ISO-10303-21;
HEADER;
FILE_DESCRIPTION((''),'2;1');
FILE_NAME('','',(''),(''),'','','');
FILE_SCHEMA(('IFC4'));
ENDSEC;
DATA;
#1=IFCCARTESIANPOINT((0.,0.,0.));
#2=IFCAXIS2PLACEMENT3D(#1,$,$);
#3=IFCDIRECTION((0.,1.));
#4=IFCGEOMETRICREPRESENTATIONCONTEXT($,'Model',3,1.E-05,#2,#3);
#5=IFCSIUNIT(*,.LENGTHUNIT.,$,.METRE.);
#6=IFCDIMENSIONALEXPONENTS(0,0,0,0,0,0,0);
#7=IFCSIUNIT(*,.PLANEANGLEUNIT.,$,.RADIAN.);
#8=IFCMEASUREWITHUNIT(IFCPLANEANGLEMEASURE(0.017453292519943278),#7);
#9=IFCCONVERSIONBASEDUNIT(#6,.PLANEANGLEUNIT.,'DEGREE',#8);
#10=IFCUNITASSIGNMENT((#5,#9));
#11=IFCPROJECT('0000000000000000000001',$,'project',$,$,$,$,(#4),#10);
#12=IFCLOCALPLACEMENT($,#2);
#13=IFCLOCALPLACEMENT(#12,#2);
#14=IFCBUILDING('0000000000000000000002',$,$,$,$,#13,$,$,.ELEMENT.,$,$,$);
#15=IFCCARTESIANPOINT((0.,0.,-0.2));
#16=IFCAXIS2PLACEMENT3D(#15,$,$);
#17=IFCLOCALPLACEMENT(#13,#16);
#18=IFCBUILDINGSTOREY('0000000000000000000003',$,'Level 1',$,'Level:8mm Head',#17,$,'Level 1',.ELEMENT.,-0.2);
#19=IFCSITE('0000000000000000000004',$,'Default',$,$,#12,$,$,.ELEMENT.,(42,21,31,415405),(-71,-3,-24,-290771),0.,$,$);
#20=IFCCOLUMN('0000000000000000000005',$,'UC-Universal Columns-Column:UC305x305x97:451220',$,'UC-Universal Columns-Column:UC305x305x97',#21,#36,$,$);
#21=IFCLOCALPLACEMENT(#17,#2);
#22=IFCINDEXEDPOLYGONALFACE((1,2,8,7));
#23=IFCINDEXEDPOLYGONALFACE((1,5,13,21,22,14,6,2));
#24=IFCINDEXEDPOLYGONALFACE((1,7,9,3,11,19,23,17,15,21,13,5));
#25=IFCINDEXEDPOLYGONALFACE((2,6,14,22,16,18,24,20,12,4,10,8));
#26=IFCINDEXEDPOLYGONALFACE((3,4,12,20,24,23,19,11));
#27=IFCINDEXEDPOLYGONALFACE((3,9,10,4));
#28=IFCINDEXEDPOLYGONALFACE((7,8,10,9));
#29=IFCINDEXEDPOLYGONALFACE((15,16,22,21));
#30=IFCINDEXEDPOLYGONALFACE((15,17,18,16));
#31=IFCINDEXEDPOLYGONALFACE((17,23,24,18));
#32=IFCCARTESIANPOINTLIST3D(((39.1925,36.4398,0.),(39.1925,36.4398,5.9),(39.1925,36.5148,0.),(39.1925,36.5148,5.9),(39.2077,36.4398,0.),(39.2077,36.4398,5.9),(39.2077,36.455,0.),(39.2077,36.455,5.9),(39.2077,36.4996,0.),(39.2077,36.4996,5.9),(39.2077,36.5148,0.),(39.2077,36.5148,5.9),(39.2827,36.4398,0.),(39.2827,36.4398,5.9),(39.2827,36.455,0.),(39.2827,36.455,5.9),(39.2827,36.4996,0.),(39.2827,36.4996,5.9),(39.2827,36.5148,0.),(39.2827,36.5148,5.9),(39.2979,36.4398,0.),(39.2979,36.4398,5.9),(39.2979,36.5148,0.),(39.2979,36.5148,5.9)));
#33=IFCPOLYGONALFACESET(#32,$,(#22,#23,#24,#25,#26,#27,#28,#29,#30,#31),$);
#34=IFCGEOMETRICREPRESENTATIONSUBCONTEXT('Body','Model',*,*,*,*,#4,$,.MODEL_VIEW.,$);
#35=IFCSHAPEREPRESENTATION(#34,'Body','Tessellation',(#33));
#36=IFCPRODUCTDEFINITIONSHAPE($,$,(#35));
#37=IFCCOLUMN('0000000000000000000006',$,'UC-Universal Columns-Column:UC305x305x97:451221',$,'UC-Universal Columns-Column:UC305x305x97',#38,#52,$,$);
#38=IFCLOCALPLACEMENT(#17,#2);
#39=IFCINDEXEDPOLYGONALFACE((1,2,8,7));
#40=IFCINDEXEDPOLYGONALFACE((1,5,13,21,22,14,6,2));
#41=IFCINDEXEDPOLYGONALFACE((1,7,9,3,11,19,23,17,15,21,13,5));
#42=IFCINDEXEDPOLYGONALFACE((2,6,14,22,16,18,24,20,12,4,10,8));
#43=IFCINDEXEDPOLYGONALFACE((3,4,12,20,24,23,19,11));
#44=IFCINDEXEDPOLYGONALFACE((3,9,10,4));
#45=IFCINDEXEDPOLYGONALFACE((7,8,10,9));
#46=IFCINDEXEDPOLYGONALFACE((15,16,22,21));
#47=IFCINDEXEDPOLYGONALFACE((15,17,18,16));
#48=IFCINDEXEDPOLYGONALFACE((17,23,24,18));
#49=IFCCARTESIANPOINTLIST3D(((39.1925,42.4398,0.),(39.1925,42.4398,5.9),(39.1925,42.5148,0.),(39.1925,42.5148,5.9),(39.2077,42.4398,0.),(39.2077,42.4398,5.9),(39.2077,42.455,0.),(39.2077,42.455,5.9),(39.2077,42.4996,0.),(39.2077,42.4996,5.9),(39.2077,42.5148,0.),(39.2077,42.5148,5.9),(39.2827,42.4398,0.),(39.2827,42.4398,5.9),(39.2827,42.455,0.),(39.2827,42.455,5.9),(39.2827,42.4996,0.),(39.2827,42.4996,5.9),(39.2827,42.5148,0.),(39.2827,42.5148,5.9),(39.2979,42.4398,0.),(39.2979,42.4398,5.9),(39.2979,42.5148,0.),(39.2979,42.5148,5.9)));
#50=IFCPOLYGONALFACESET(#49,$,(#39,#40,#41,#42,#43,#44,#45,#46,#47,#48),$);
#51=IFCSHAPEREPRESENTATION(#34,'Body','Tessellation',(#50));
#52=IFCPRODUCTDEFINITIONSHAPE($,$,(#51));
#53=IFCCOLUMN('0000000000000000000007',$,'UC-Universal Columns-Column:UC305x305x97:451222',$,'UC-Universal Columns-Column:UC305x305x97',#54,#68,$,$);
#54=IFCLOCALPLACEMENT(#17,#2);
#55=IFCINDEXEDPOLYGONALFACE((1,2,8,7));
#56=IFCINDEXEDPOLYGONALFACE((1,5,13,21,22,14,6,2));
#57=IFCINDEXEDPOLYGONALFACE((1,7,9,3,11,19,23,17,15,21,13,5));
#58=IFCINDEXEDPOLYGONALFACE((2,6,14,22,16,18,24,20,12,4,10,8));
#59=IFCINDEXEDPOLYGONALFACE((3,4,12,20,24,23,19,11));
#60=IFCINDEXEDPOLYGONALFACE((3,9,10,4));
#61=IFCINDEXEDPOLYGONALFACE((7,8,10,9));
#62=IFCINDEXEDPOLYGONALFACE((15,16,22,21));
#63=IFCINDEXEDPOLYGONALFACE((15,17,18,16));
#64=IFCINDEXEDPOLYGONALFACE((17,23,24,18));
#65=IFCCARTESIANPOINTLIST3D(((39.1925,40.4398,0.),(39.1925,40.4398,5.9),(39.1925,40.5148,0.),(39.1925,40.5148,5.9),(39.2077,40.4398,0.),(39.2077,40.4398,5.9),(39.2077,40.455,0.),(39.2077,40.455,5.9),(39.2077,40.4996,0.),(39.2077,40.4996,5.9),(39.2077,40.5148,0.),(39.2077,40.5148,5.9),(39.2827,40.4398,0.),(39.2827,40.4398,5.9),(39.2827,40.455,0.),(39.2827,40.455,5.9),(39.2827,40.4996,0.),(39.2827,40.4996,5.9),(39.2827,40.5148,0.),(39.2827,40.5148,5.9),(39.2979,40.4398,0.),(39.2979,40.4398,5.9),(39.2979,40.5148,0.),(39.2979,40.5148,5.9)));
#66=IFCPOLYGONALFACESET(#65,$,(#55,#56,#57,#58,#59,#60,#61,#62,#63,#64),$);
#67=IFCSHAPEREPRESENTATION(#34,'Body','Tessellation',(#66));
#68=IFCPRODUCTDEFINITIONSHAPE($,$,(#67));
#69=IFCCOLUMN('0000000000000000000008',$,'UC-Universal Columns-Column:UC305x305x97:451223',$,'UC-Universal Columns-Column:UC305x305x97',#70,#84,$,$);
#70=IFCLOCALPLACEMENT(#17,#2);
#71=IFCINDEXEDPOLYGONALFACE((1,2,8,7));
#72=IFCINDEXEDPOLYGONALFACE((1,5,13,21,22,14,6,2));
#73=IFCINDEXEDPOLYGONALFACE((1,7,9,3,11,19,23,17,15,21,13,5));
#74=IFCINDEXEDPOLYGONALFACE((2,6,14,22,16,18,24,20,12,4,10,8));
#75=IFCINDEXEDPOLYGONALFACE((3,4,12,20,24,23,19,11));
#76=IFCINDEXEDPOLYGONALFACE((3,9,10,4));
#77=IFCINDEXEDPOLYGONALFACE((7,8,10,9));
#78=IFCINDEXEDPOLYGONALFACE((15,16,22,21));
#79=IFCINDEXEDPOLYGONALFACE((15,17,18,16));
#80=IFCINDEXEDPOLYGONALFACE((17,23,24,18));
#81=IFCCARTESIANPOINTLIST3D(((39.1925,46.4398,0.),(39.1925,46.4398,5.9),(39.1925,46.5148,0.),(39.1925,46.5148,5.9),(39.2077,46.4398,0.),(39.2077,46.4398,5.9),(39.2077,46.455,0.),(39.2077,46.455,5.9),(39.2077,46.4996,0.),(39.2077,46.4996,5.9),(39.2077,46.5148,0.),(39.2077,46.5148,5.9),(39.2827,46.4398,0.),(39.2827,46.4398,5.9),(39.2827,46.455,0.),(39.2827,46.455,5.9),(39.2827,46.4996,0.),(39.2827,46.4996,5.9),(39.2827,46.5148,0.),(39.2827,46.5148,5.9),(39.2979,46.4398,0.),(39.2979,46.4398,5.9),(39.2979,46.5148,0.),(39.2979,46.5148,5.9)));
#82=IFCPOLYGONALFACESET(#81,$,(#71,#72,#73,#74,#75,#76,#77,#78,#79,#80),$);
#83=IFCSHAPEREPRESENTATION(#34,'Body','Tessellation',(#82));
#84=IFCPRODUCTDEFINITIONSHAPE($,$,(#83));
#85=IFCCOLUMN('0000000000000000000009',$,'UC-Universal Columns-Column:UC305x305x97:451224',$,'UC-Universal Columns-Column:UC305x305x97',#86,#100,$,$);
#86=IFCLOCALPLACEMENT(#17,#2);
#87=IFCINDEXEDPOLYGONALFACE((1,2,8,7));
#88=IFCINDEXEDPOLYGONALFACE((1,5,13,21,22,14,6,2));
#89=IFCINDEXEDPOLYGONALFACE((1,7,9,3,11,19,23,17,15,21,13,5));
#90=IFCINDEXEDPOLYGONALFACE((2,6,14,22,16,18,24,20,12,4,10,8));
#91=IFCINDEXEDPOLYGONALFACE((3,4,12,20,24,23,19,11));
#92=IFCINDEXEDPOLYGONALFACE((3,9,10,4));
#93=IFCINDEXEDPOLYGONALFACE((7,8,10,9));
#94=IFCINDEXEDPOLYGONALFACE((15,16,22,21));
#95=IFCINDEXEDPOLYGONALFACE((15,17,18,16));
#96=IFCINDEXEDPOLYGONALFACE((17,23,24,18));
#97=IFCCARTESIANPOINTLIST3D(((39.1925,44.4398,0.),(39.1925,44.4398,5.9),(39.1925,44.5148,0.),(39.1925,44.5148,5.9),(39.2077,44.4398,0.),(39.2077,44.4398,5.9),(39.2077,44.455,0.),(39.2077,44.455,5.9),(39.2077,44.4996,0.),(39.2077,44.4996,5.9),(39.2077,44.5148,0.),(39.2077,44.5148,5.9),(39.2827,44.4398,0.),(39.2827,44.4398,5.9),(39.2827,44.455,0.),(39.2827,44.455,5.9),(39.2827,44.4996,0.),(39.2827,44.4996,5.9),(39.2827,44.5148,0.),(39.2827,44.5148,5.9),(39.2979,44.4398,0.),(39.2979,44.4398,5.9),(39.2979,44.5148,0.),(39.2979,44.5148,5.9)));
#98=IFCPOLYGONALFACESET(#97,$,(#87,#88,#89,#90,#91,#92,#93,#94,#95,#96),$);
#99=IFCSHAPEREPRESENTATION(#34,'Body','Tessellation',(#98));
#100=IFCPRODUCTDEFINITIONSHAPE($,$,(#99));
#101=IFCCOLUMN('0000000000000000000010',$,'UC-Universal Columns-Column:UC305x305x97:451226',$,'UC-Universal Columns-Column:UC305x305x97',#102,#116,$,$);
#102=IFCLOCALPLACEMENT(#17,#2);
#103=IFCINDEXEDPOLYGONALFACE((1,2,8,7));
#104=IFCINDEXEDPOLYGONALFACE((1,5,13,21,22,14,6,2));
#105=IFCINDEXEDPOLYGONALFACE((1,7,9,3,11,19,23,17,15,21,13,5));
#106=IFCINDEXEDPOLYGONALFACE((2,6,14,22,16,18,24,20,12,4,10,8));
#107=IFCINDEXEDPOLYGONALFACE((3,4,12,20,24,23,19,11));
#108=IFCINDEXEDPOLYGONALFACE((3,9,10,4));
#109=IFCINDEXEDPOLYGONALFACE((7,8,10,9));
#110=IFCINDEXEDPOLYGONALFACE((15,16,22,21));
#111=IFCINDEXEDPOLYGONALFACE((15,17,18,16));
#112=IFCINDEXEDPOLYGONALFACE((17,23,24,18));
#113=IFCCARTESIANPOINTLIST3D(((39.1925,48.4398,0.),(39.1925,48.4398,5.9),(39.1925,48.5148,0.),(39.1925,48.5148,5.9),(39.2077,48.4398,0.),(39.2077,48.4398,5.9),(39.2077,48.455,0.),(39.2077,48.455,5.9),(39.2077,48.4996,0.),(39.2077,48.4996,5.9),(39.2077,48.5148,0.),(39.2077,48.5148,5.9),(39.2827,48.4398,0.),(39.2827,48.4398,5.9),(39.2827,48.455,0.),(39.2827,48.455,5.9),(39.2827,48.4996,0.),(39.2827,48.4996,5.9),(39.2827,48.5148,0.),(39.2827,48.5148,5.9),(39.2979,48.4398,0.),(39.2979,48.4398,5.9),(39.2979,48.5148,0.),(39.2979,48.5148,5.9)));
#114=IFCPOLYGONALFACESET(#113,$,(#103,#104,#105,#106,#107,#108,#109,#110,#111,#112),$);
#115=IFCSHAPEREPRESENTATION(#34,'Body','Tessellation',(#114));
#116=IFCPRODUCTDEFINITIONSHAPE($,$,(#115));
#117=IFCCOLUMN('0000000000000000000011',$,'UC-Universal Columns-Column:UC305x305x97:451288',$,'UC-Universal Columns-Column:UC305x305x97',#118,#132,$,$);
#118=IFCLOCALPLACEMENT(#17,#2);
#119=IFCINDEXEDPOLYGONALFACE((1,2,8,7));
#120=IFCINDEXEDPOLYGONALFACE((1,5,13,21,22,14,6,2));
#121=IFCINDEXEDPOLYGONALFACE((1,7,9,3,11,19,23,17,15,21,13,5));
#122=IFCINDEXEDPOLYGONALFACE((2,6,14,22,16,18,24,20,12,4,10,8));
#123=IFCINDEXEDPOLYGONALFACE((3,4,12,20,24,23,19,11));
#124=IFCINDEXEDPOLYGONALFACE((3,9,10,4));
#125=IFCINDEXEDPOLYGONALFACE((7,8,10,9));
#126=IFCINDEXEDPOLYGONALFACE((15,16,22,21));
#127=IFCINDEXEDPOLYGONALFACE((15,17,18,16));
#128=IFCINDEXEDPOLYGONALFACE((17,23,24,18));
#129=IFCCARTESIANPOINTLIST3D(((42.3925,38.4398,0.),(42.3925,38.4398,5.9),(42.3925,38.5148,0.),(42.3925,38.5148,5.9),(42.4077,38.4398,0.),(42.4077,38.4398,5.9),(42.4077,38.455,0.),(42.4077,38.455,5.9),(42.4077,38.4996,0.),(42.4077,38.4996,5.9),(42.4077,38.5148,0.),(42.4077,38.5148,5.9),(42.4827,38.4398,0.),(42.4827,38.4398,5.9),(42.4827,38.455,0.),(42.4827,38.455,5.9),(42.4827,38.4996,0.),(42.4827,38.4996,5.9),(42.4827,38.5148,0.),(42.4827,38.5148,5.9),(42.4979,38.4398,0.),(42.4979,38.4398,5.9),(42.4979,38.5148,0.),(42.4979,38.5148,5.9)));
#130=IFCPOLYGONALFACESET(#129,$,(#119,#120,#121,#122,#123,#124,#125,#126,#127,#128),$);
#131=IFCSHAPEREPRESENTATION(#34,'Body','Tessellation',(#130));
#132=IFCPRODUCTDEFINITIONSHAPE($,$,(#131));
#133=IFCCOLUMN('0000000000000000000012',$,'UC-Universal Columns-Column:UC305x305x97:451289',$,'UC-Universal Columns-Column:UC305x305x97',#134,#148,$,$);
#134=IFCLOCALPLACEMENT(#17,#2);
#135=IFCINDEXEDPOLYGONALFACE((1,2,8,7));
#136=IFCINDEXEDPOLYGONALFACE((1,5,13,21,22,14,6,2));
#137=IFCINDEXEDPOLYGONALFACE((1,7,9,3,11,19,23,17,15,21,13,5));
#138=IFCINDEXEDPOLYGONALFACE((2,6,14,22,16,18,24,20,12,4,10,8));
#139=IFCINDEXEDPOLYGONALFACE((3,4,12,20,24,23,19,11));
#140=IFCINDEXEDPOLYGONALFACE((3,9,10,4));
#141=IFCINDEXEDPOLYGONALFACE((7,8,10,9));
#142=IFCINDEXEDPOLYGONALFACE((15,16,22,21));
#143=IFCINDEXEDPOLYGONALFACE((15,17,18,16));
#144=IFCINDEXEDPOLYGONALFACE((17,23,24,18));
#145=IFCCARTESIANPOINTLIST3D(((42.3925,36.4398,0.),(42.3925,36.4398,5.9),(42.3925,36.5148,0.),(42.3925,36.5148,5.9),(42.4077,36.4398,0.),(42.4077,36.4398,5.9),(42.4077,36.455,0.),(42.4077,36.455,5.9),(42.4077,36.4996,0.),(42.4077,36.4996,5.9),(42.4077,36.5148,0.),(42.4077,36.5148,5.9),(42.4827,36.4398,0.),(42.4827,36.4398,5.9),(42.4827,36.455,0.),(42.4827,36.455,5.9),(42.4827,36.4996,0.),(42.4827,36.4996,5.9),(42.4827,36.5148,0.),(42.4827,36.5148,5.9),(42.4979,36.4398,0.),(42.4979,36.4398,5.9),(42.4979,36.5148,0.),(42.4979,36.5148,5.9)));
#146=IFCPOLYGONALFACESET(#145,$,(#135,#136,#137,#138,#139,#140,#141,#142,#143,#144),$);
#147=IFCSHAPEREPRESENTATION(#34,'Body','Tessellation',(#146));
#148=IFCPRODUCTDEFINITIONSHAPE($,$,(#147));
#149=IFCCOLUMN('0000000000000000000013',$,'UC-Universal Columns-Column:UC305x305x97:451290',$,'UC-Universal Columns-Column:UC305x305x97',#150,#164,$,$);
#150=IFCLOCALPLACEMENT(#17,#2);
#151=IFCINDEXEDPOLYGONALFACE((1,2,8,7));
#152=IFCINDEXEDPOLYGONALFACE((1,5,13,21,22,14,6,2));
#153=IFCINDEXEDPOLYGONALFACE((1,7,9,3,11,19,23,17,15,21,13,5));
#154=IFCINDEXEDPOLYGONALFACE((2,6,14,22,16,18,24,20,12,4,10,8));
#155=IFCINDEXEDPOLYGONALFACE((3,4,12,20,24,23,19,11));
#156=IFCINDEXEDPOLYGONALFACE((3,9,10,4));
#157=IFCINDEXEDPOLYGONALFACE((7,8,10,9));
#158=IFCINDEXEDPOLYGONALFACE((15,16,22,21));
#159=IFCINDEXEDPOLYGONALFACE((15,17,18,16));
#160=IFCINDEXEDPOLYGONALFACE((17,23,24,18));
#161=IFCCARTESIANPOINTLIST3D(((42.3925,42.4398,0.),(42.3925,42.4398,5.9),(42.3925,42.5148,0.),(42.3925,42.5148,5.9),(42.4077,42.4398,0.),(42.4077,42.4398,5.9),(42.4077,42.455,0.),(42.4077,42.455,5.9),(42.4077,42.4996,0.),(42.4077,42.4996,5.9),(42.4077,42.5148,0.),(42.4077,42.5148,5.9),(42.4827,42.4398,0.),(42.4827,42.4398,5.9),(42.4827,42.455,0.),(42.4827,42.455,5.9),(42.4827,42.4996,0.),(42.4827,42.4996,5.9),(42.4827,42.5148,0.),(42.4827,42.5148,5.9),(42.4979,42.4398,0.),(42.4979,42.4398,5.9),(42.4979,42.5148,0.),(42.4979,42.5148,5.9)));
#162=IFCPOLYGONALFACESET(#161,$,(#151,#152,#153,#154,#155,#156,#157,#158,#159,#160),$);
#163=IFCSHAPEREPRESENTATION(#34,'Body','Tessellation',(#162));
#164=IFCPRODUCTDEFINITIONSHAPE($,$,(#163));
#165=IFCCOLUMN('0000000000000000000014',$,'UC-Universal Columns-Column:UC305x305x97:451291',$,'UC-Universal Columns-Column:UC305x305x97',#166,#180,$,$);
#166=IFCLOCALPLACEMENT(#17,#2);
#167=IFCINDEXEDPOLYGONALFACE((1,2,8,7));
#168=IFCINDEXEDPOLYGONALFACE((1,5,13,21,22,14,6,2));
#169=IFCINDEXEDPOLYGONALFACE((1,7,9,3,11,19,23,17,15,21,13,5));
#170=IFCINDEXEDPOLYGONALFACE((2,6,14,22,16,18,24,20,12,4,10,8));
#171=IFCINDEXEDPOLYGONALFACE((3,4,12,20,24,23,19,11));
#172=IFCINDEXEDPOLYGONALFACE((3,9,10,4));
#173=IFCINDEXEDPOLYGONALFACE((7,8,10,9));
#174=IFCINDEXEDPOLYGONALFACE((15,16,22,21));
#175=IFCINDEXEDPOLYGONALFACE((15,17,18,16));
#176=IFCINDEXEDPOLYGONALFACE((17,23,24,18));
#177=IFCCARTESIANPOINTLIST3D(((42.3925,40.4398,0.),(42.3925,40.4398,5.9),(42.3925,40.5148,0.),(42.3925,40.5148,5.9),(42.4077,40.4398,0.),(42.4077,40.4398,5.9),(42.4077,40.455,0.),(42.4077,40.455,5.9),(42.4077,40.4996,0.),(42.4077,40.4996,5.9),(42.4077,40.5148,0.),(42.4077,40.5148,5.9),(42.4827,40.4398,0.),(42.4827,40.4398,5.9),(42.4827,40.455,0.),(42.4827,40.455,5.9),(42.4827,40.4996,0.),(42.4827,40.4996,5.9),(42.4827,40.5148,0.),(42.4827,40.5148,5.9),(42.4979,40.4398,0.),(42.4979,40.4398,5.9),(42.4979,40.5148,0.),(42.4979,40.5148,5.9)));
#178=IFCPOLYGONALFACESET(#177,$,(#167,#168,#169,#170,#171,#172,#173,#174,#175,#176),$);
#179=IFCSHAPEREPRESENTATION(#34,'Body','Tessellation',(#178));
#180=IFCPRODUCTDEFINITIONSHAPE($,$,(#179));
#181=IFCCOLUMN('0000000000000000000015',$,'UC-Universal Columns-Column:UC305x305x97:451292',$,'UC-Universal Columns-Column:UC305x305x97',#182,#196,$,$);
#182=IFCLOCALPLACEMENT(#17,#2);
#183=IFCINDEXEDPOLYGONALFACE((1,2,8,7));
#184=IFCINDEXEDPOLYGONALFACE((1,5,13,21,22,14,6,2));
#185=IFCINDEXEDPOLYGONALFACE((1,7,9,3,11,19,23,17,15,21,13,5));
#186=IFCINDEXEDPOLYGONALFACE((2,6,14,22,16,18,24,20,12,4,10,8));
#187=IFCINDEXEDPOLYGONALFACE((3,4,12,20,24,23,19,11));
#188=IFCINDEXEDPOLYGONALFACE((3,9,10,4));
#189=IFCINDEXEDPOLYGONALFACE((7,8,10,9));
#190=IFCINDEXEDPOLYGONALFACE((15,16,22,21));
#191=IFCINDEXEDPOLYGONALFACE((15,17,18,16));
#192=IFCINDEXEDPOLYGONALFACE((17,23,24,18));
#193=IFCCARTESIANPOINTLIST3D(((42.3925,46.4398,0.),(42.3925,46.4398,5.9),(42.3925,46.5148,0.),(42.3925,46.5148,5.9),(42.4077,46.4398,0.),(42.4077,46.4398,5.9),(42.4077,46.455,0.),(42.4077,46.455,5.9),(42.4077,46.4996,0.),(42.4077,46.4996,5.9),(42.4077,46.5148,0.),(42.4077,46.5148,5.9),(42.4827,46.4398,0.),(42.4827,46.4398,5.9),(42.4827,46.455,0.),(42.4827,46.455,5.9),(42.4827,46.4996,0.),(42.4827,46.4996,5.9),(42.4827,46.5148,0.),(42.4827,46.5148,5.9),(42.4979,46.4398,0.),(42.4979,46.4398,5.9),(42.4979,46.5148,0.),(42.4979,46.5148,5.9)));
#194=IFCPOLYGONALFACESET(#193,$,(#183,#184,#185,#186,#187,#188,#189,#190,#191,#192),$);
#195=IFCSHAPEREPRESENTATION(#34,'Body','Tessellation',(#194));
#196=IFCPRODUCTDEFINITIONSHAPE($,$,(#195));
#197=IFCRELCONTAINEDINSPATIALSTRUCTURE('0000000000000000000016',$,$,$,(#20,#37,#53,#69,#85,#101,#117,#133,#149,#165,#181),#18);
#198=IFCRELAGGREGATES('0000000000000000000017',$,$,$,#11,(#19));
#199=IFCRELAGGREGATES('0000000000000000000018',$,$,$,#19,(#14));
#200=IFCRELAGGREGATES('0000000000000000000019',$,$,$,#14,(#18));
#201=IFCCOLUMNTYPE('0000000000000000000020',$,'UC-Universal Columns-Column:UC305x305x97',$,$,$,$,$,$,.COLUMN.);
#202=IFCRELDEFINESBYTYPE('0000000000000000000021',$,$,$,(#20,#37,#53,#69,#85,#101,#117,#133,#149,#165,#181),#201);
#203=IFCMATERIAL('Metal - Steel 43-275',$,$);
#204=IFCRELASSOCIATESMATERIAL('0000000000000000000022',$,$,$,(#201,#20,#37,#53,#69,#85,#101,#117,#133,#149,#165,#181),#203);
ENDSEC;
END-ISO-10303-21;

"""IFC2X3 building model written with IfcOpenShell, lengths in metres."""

from ifc_helpers import new_model, entity, si_unit, converted_unit, direction, frame, frame_2d, origin, place, context, subcontext, project, spatial, polyline, circle_curve, parameter, trimmed, segment, composite_curve, outline, extrude, source, transform, mapped, material, type_object, type_shapes, element, save


model = new_model("IFC2X3")

# Units and contexts
model_context = context("Model", 3, precision=1e-05, world=origin(), true_north=direction((0.0, 1.0)))
body_context = subcontext(model_context, "Body", "Model", "MODEL_VIEW")
ifc_project = project(units=[si_unit("LENGTHUNIT", "METRE"), converted_unit("PLANEANGLEUNIT", "DEGREE", entity("IfcPlaneAngleMeasure", 0.017453292519943278), si_unit("PLANEANGLEUNIT", "RADIAN"), dimensions=[0, 0, 0, 0, 0, 0, 0])], contexts=[model_context])

# Site, building, storey
site_placement = place(None, origin())
site = spatial("IfcSite", under=ifc_project, at=site_placement, Name="Default", CompositionType="ELEMENT", RefLatitude=(42, 21, 31, 415405), RefLongitude=(-71, -3, -24, -290771), RefElevation=0.0)
building_placement = place(site_placement, origin())
building = spatial("IfcBuilding", under=site, at=building_placement, CompositionType="ELEMENT")
storey_placement = place(building_placement, frame((0.0, 0.0, -0.2)))
storey = spatial("IfcBuildingStorey", under=building, at=storey_placement, Name="Level 1", ObjectType="Level:8mm Head", LongName="Level 1", CompositionType="ELEMENT", Elevation=-0.2)

# Columns
ifc_material = material(Name="Metal - Steel 43-275")
column_type = type_object("IfcColumnType", Name="UC-Universal Columns-Column:UC305x305x97", PredefinedType="COLUMN", material=ifc_material)
shared_shape = source(origin(), body_context, "Body", "SweptSolid", [
    extrude(outline(composite_curve([segment(polyline([(-0.0375, -0.0375), (0.0375, -0.0375)]), True, "CONTINUOUS"), segment(polyline([(0.0375, -0.0375), (0.0527, -0.0375)]), True, "CONTINUOUS"), segment(trimmed(circle_curve(frame_2d((0.0527, -0.0223), x_axis=(-1.0, 0.0)), 0.0152), [parameter(0.0)], [parameter(90.0)], True, "PARAMETER"), False, "CONTINUOUS"), segment(polyline([(0.0375, -0.0223), (0.0375, 0.0223)]), True, "CONTINUOUS"), segment(trimmed(circle_curve(frame_2d((0.0527, 0.0223), x_axis=(-1.0, 0.0)), 0.0152), [parameter(270.0)], [parameter(0.0)], True, "PARAMETER"), False, "CONTINUOUS"), segment(polyline([(0.0527, 0.0375), (0.0375, 0.0375)]), True, "CONTINUOUS"), segment(polyline([(0.0375, 0.0375), (-0.0375, 0.0375)]), True, "CONTINUOUS"), segment(polyline([(-0.0375, 0.0375), (-0.0527, 0.0375)]), True, "CONTINUOUS"), segment(trimmed(circle_curve(frame_2d((-0.0527, 0.0223), x_axis=(-1.0, 0.0)), 0.0152), [parameter(180.0)], [parameter(270.0)], True, "PARAMETER"), False, "CONTINUOUS"), segment(polyline([(-0.0375, 0.0223), (-0.0375, -0.0223)]), True, "CONTINUOUS"), segment(trimmed(circle_curve(frame_2d((-0.0527, -0.0223), x_axis=(-1.0, 0.0)), 0.0152), [parameter(90.0)], [parameter(180.0)], True, "PARAMETER"), False, "CONTINUOUS"), segment(polyline([(-0.0527, -0.0375), (-0.0375, -0.0375)]), True, "CONTINUOUS")], self_intersect=False)), frame((0.0, 0.0, -0.2), z_axis=(0.0, 0.0, 1.0), x_axis=(-1.0, 0.0, 0.0)), (0.0, 0.0, 1.0), 5.9),
])
type_shapes(column_type, [shared_shape])
for number, where, z_axis, x_axis, name in (
    (1, (39.2452, 36.4773, 0.2), (0.0, 0.0, 1.0), (-1.0, 0.0, 0.0), "UC-Universal Columns-Column:UC305x305x97:451220"),
    (2, (39.2452, 42.4773, 0.2), (0.0, 0.0, 1.0), (-1.0, 0.0, 0.0), "UC-Universal Columns-Column:UC305x305x97:451221"),
    (3, (39.2452, 40.4773, 0.2), (0.0, 0.0, 1.0), (-1.0, 0.0, 0.0), "UC-Universal Columns-Column:UC305x305x97:451222"),
    (4, (39.2452, 46.4773, 0.2), (0.0, 0.0, 1.0), (-1.0, 0.0, 0.0), "UC-Universal Columns-Column:UC305x305x97:451223"),
    (5, (39.2452, 44.4773, 0.2), (0.0, 0.0, 1.0), (-1.0, 0.0, 0.0), "UC-Universal Columns-Column:UC305x305x97:451224"),
    (6, (39.2452, 48.4773, 0.2), (0.0, 0.0, 1.0), (-1.0, 0.0, 0.0), "UC-Universal Columns-Column:UC305x305x97:451226"),
    (7, (42.4452, 38.4773, 0.2), (0.0, 0.0, 1.0), (-1.0, 0.0, 0.0), "UC-Universal Columns-Column:UC305x305x97:451288"),
    (8, (42.4452, 36.4773, 0.2), (0.0, 0.0, 1.0), (-1.0, 0.0, 0.0), "UC-Universal Columns-Column:UC305x305x97:451289"),
    (9, (42.4452, 42.4773, 0.2), (0.0, 0.0, 1.0), (-1.0, 0.0, 0.0), "UC-Universal Columns-Column:UC305x305x97:451290"),
    (10, (42.4452, 40.4773, 0.2), (0.0, 0.0, 1.0), (-1.0, 0.0, 0.0), "UC-Universal Columns-Column:UC305x305x97:451291"),
    (11, (42.4452, 46.4773, 0.2), (0.0, 0.0, 1.0), (-1.0, 0.0, 0.0), "UC-Universal Columns-Column:UC305x305x97:451292"),
):
    element("IfcColumn", number, at=place(storey_placement, frame(where, z_axis=z_axis, x_axis=x_axis)), inside=storey, type_object=column_type, material=ifc_material, Name=name, ObjectType="UC-Universal Columns-Column:UC305x305x97", context=body_context, shape_type="MappedRepresentation", body=[
        mapped(shared_shape, transform((0.0, 0.0, 0.0), scale=1.0)),
    ])

save(model, "model.ifc")
